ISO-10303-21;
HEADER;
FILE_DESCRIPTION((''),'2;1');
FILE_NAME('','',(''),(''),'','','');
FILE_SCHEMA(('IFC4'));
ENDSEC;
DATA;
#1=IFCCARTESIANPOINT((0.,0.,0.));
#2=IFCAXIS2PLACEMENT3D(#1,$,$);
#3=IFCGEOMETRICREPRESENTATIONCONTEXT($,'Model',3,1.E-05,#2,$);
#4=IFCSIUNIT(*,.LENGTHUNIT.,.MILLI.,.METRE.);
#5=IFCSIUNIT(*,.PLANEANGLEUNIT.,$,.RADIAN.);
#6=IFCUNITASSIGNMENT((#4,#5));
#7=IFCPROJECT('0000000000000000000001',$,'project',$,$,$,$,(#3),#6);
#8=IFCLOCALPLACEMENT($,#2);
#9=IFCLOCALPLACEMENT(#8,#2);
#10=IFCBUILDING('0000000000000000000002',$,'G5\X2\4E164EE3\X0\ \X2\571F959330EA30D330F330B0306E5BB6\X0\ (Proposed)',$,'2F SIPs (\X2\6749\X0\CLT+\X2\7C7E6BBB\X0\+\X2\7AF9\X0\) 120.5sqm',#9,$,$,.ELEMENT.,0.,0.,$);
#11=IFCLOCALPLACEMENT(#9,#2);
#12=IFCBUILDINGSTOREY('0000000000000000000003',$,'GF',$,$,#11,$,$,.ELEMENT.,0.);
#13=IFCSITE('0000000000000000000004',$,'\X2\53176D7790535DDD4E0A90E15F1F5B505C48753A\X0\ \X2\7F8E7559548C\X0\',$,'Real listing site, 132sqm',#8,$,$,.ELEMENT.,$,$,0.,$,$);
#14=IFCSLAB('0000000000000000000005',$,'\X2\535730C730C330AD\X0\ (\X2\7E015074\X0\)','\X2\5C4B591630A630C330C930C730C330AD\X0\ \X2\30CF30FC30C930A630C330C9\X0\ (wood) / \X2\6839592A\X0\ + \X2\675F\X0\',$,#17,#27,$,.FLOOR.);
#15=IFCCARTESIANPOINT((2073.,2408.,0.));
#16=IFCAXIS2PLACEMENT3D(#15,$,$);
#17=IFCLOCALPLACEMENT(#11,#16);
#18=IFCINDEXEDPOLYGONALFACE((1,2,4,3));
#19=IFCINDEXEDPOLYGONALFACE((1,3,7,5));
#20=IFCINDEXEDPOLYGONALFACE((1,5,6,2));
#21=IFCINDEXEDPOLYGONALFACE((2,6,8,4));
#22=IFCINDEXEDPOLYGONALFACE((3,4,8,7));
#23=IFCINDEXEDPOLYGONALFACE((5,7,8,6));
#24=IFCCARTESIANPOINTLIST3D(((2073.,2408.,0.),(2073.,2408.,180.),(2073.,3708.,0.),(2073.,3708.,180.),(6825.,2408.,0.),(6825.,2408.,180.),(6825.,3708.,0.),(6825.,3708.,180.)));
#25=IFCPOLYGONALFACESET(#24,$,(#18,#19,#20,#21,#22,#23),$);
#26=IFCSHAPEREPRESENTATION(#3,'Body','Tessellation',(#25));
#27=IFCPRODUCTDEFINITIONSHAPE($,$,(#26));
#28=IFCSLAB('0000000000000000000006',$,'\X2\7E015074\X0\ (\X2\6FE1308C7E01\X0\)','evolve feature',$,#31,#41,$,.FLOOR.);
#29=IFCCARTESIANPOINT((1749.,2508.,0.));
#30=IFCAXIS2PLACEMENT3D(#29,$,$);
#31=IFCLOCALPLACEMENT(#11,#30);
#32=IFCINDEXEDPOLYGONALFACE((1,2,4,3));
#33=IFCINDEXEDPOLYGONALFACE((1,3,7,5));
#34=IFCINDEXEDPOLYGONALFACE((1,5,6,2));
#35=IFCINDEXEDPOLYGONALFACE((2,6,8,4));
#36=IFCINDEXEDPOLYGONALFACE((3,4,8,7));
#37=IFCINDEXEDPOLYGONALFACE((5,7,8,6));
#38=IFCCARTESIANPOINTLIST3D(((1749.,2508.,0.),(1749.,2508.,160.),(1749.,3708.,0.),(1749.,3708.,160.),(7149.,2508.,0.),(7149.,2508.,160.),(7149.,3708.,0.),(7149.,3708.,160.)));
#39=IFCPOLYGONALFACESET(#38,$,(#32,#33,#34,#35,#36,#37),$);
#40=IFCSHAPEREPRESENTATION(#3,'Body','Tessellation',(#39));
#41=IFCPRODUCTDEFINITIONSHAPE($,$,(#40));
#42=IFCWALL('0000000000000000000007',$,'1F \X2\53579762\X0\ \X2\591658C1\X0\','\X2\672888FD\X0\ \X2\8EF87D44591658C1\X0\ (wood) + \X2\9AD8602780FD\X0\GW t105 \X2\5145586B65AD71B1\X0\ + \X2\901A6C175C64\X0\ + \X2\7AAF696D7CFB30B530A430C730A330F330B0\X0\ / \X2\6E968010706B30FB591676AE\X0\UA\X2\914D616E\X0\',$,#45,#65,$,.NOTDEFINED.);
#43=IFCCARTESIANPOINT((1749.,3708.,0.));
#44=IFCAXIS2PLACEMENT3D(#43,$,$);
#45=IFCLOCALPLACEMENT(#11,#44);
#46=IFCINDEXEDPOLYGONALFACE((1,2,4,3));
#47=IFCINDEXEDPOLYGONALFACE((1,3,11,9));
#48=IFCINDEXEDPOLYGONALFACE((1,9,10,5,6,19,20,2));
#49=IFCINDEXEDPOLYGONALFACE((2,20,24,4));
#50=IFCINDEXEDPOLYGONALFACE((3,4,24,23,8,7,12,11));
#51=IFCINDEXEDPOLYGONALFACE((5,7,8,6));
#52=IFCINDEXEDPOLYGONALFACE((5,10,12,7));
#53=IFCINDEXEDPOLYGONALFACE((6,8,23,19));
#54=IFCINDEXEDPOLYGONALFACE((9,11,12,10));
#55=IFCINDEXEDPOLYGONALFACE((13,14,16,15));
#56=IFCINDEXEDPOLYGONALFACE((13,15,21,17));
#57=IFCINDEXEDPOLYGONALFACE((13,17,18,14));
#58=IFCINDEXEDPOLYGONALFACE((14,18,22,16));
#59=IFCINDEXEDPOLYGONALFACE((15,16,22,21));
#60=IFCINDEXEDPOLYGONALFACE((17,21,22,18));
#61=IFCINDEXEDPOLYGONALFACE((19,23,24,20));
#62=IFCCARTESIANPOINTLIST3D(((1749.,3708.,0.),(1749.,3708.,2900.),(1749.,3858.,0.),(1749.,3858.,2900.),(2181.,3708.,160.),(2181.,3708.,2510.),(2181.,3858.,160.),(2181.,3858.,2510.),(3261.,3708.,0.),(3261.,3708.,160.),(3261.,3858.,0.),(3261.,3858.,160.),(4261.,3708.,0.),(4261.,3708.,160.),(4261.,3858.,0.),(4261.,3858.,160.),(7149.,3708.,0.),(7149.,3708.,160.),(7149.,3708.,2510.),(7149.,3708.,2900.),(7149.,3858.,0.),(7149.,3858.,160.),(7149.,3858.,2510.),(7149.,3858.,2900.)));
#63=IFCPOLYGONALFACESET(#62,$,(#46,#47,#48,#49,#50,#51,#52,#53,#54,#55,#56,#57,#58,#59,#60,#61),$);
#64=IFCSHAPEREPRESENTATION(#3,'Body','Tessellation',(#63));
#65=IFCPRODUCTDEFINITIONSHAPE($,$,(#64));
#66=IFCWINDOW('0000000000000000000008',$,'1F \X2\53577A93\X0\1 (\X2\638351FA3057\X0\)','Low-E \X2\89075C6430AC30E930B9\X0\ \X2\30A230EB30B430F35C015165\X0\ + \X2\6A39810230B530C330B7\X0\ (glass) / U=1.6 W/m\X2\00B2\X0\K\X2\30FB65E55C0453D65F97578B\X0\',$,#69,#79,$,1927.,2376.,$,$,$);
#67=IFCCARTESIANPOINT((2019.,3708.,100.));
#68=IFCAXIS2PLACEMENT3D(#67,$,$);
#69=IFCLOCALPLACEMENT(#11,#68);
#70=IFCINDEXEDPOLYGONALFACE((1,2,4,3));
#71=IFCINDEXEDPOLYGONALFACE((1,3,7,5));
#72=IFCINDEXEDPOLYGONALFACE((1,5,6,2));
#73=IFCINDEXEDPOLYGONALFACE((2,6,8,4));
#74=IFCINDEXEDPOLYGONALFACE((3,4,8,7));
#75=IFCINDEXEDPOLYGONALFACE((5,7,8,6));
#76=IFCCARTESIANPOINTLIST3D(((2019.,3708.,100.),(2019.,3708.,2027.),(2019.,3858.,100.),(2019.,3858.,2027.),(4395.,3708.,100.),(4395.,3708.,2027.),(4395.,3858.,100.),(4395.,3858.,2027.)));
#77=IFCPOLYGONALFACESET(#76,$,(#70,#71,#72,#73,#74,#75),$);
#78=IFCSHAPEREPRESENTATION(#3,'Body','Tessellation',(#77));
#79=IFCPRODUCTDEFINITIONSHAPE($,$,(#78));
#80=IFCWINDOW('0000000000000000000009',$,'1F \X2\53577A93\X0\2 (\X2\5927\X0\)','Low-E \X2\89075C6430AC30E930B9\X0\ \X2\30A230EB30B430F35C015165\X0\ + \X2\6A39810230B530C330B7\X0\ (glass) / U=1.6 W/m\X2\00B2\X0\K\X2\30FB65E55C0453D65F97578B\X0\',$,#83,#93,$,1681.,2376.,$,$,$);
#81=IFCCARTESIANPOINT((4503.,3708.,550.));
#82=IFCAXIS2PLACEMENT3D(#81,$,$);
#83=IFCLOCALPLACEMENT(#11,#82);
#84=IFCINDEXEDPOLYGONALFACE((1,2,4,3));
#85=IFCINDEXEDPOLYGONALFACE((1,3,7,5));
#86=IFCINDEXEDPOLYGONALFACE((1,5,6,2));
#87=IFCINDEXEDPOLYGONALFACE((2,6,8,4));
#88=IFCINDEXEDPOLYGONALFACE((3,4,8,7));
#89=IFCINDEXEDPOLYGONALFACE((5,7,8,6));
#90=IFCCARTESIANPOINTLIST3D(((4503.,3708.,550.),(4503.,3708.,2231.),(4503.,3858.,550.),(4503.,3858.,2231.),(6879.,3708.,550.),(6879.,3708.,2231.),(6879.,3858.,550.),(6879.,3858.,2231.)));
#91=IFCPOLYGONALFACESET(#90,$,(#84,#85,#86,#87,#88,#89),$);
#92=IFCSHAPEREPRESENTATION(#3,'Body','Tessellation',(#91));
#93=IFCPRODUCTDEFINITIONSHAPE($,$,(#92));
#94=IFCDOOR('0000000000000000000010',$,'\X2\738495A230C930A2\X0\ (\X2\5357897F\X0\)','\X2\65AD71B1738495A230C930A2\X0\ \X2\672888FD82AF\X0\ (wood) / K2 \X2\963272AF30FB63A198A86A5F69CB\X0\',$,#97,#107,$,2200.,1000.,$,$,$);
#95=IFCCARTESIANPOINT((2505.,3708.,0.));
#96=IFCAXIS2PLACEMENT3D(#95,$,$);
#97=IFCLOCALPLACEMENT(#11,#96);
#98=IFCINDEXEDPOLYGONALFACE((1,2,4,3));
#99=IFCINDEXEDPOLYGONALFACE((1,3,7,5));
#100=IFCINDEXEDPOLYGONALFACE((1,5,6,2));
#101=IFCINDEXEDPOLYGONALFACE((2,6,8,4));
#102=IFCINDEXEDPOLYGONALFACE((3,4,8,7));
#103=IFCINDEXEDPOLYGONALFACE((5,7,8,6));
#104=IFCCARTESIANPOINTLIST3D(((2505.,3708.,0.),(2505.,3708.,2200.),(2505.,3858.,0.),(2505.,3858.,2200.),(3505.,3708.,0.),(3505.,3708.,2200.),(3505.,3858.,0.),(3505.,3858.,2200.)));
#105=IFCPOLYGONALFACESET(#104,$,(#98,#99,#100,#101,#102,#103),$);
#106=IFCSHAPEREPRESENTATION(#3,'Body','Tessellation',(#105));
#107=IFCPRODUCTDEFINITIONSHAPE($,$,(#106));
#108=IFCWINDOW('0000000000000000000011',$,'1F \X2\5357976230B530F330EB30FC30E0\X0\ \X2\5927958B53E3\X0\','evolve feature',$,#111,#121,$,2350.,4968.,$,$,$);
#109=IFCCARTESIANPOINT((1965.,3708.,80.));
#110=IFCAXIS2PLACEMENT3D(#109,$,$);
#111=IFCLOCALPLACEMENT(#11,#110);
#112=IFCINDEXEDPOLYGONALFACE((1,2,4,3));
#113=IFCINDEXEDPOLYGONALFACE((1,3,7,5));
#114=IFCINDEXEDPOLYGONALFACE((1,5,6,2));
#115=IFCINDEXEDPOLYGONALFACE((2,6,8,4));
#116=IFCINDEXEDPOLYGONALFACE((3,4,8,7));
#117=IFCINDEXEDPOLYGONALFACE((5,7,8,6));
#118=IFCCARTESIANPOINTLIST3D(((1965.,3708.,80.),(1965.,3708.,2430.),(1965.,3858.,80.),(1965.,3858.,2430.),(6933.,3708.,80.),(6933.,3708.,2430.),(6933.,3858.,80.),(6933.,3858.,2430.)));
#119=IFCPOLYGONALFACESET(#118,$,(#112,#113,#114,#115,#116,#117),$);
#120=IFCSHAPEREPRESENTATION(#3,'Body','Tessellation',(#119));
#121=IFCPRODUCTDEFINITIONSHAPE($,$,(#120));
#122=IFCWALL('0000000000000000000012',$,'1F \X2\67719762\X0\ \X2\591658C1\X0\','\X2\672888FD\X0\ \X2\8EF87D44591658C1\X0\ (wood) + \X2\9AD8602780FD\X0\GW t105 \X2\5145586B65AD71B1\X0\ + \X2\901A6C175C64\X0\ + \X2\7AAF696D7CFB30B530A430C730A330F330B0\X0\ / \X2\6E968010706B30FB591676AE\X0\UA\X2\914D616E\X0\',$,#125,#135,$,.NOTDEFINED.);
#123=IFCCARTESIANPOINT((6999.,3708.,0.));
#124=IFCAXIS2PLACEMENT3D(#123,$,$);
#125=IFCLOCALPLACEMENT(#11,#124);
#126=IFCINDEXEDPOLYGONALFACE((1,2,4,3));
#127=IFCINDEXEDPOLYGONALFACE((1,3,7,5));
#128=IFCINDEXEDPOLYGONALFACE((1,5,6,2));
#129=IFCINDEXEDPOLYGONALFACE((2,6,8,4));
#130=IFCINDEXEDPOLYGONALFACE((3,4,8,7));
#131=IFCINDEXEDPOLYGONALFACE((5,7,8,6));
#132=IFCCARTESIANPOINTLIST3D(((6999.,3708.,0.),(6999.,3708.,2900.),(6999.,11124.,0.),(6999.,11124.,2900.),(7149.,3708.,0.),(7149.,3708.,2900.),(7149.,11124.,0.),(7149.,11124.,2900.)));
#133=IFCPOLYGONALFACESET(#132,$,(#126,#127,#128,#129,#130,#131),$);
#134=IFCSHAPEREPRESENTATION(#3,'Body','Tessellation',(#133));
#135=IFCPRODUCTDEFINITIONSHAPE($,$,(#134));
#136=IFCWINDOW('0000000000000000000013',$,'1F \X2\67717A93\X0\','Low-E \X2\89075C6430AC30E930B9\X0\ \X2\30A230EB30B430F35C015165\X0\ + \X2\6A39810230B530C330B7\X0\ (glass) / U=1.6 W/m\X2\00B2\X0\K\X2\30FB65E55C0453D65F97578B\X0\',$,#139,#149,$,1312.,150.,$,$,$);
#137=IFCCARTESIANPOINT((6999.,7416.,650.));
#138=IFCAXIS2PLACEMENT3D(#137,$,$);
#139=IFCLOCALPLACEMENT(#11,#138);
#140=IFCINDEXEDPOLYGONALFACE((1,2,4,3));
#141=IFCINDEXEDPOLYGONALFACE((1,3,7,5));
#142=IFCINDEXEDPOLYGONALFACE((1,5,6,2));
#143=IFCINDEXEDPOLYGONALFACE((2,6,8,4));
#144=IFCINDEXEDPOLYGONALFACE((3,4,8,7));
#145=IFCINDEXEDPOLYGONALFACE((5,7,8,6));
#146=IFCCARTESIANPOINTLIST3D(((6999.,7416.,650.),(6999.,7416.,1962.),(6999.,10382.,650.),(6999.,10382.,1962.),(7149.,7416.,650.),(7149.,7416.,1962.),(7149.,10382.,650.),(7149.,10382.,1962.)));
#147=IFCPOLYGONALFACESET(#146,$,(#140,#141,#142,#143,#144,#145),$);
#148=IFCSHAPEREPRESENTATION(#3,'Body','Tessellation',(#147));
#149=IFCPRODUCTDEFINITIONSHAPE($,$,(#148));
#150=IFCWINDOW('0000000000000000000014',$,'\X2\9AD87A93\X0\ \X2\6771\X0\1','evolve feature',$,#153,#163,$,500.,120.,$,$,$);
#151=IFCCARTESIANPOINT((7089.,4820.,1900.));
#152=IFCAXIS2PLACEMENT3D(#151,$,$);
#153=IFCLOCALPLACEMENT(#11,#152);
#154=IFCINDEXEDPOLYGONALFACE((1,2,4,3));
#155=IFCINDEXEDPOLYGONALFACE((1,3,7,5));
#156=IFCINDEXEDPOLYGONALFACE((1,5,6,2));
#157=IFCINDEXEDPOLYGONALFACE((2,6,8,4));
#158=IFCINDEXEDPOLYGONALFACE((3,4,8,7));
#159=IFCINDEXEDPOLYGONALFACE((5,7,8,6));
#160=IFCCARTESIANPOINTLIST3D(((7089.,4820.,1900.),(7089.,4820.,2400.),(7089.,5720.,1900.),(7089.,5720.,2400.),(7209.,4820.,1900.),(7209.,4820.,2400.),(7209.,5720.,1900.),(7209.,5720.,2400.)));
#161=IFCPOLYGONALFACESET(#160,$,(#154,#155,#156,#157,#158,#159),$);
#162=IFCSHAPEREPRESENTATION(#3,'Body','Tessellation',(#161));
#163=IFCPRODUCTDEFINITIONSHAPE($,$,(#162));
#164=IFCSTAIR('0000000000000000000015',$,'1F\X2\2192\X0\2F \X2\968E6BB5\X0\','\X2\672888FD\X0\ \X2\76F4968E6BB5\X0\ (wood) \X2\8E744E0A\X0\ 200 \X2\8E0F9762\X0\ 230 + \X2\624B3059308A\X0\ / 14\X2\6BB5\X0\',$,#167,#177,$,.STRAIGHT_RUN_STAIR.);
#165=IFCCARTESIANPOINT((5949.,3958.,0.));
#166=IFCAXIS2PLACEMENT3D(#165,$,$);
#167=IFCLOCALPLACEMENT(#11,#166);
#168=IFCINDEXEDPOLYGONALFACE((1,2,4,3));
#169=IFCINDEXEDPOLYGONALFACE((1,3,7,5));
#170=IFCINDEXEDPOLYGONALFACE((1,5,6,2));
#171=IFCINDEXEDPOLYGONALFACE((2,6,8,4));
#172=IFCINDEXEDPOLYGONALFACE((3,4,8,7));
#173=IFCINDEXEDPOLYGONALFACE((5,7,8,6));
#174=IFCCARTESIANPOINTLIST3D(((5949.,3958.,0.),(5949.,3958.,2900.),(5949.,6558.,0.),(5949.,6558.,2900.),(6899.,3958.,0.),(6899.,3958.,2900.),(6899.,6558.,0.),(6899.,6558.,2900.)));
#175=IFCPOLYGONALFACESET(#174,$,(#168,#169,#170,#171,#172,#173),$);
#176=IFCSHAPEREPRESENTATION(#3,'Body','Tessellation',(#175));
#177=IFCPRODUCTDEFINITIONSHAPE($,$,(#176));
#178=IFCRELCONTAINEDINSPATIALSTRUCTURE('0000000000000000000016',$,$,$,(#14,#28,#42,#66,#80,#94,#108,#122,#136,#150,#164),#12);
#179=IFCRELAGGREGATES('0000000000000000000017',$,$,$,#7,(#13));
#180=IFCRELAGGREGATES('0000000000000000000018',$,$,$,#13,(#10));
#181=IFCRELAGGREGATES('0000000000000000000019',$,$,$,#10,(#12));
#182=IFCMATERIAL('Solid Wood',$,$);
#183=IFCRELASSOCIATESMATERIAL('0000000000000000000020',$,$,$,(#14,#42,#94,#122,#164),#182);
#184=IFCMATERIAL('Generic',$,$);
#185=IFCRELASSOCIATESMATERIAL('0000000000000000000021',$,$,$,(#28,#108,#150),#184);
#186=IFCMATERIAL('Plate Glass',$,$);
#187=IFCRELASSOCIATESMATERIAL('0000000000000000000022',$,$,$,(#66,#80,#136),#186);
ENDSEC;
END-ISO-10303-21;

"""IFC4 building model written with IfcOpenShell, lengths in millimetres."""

from ifc_helpers import new_model, si_unit, frame, frame_2d, origin, place, context, project, spatial, rectangle, extrude, material, element, fill, save


model = new_model("IFC4")

# Units and contexts
model_context = context("Model", 3, precision=1e-05, world=origin())
ifc_project = project(units=[si_unit("LENGTHUNIT", "METRE", prefix="MILLI"), si_unit("PLANEANGLEUNIT", "RADIAN")], contexts=[model_context])

# Site, building, storey
site_placement = place(None, origin())
site = spatial("IfcSite", under=ifc_project, at=site_placement, Name="北海道川上郡弟子屈町 美留和", ObjectType="Real listing site, 132sqm", CompositionType="ELEMENT", RefElevation=0.0)
building_placement = place(site_placement, origin())
building = spatial("IfcBuilding", under=site, at=building_placement, Name="G5世代 土間リビングの家 (Proposed)", ObjectType="2F SIPs (杉CLT+籾殻+竹) 120.5sqm", CompositionType="ELEMENT", ElevationOfRefHeight=0.0, ElevationOfTerrain=0.0)
storey_placement = place(building_placement, origin())
storey = spatial("IfcBuildingStorey", under=building, at=storey_placement, Name="GF", CompositionType="ELEMENT", Elevation=0.0)

# Slabs
ifc_material_1 = material(Name="Solid Wood")
slab_1_placement = place(storey_placement, frame((2073.0, 2408.0, 0.0)))
element("IfcSlab", 1, at=slab_1_placement, inside=storey, material=ifc_material_1, Name="南デッキ (縁側)", Description="屋外ウッドデッキ ハードウッド (wood) / 根太 + 束", PredefinedType="FLOOR", context=model_context, shape_type="SweptSolid", body=[
    extrude(rectangle(XDim=4752.0, YDim=1300.0, at=frame_2d((2376.0, 650.0))), frame((2073.0, 2408.0, 0.0)), (0.0, 0.0, 1.0), 180.0),
])
ifc_material_2 = material(Name="Generic")
slab_2_placement = place(storey_placement, frame((1749.0, 2508.0, 0.0)))
element("IfcSlab", 2, at=slab_2_placement, inside=storey, material=ifc_material_2, Name="縁側 (濡れ縁)", Description="evolve feature", PredefinedType="FLOOR", context=model_context, shape_type="SweptSolid", body=[
    extrude(rectangle(XDim=5400.0, YDim=1200.0, at=frame_2d((2700.0, 600.0))), frame((1749.0, 2508.0, 0.0)), (0.0, 0.0, 1.0), 160.0),
])

# Wall, openings, windows, door
wall_1_placement = place(storey_placement, frame((1749.0, 3708.0, 0.0)))
wall_1 = element("IfcWall", 3, at=wall_1_placement, inside=storey, material=ifc_material_1, Name="1F 南面 外壁", Description="木製 軸組外壁 (wood) + 高性能GW t105 充填断熱 + 通気層 + 窯業系サイディング / 準耐火・外皮UA配慮", PredefinedType="NOTDEFINED", context=model_context, shape_type="SweptSolid", body=[
    extrude(rectangle(XDim=5400.0, YDim=150.0, at=frame_2d((2700.0, 75.0))), frame((1749.0, 3708.0, 0.0)), (0.0, 0.0, 1.0), 2900.0),
])
opening_1_placement = place(storey_placement, frame((2019.0, 3708.0, 100.0)))
opening_1 = element("IfcOpeningElement", 4, at=opening_1_placement, cuts=wall_1, PredefinedType="NOTDEFINED", context=model_context, shape_type="SweptSolid", body=[
    extrude(rectangle(XDim=2376.0, YDim=150.0, at=frame_2d((1188.0, 75.0))), frame((2019.0, 3708.0, 100.0)), (0.0, 0.0, 1.0), 1927.0),
])
opening_2_placement = place(storey_placement, frame((4503.0, 3708.0, 550.0)))
opening_2 = element("IfcOpeningElement", 5, at=opening_2_placement, cuts=wall_1, PredefinedType="NOTDEFINED", context=model_context, shape_type="SweptSolid", body=[
    extrude(rectangle(XDim=2376.0, YDim=150.0, at=frame_2d((1188.0, 75.0))), frame((4503.0, 3708.0, 550.0)), (0.0, 0.0, 1.0), 1681.0),
])
opening_3_placement = place(storey_placement, frame((2505.0, 3708.0, 0.0)))
opening_3 = element("IfcOpeningElement", 6, at=opening_3_placement, cuts=wall_1, PredefinedType="NOTDEFINED", context=model_context, shape_type="SweptSolid", body=[
    extrude(rectangle(XDim=1000.0, YDim=150.0, at=frame_2d((500.0, 75.0))), frame((2505.0, 3708.0, 0.0)), (0.0, 0.0, 1.0), 2200.0),
])
opening_4_placement = place(storey_placement, frame((1965.0, 3708.0, 80.0)))
opening_4 = element("IfcOpeningElement", 7, at=opening_4_placement, cuts=wall_1, PredefinedType="NOTDEFINED", context=model_context, shape_type="SweptSolid", body=[
    extrude(rectangle(XDim=4968.0, YDim=150.0, at=frame_2d((2484.0, 75.0))), frame((1965.0, 3708.0, 80.0)), (0.0, 0.0, 1.0), 2350.0),
])
ifc_material_3 = material(Name="Plate Glass")
window_1_placement = place(storey_placement, frame((2019.0, 3708.0, 100.0)))
window_1 = element("IfcWindow", 8, at=window_1_placement, inside=storey, material=ifc_material_3, Name="1F 南窓1 (掃出し)", Description="Low-E 複層ガラス アルゴン封入 + 樹脂サッシ (glass) / U=1.6 W/m²K・日射取得型", OverallHeight=1927.0, OverallWidth=2376.0, context=model_context, shape_type="SweptSolid", body=[
    extrude(rectangle(XDim=2376.0, YDim=150.0, at=frame_2d((1188.0, 75.0))), frame((2019.0, 3708.0, 100.0)), (0.0, 0.0, 1.0), 1927.0),
])
fill(opening_1, window_1)
window_2_placement = place(storey_placement, frame((4503.0, 3708.0, 550.0)))
window_2 = element("IfcWindow", 9, at=window_2_placement, inside=storey, material=ifc_material_3, Name="1F 南窓2 (大)", Description="Low-E 複層ガラス アルゴン封入 + 樹脂サッシ (glass) / U=1.6 W/m²K・日射取得型", OverallHeight=1681.0, OverallWidth=2376.0, context=model_context, shape_type="SweptSolid", body=[
    extrude(rectangle(XDim=2376.0, YDim=150.0, at=frame_2d((1188.0, 75.0))), frame((4503.0, 3708.0, 550.0)), (0.0, 0.0, 1.0), 1681.0),
])
fill(opening_2, window_2)
door_placement = place(storey_placement, frame((2505.0, 3708.0, 0.0)))
door = element("IfcDoor", 10, at=door_placement, inside=storey, material=ifc_material_1, Name="玄関ドア (南西)", Description="断熱玄関ドア 木製芯 (wood) / K2 防犯・採風機構", OverallHeight=2200.0, OverallWidth=1000.0, context=model_context, shape_type="SweptSolid", body=[
    extrude(rectangle(XDim=1000.0, YDim=150.0, at=frame_2d((500.0, 75.0))), frame((2505.0, 3708.0, 0.0)), (0.0, 0.0, 1.0), 2200.0),
])
fill(opening_3, door)
window_3_placement = place(storey_placement, frame((1965.0, 3708.0, 80.0)))
window_3 = element("IfcWindow", 11, at=window_3_placement, inside=storey, material=ifc_material_2, Name="1F 南面サンルーム 大開口", Description="evolve feature", OverallHeight=2350.0, OverallWidth=4968.0, context=model_context, shape_type="SweptSolid", body=[
    extrude(rectangle(XDim=4968.0, YDim=150.0, at=frame_2d((2484.0, 75.0))), frame((1965.0, 3708.0, 80.0)), (0.0, 0.0, 1.0), 2350.0),
])
fill(opening_4, window_3)

# Wall, openings, windows
wall_2_placement = place(storey_placement, frame((6999.0, 3708.0, 0.0)))
wall_2 = element("IfcWall", 12, at=wall_2_placement, inside=storey, material=ifc_material_1, Name="1F 東面 外壁", Description="木製 軸組外壁 (wood) + 高性能GW t105 充填断熱 + 通気層 + 窯業系サイディング / 準耐火・外皮UA配慮", PredefinedType="NOTDEFINED", context=model_context, shape_type="SweptSolid", body=[
    extrude(rectangle(XDim=150.0, YDim=7416.0, at=frame_2d((75.0, 3708.0))), frame((6999.0, 3708.0, 0.0)), (0.0, 0.0, 1.0), 2900.0),
])
opening_5_placement = place(storey_placement, frame((6999.0, 7416.0, 650.0)))
opening_5 = element("IfcOpeningElement", 13, at=opening_5_placement, cuts=wall_2, PredefinedType="NOTDEFINED", context=model_context, shape_type="SweptSolid", body=[
    extrude(rectangle(XDim=150.0, YDim=2966.0, at=frame_2d((75.0, 1483.0))), frame((6999.0, 7416.0, 650.0)), (0.0, 0.0, 1.0), 1312.0),
])
opening_6_placement = place(storey_placement, frame((7089.0, 4820.0, 1900.0)))
opening_6 = element("IfcOpeningElement", 14, at=opening_6_placement, cuts=wall_2, PredefinedType="NOTDEFINED", context=model_context, shape_type="SweptSolid", body=[
    extrude(rectangle(XDim=120.0, YDim=900.0, at=frame_2d((60.0, 450.0))), frame((7089.0, 4820.0, 1900.0)), (0.0, 0.0, 1.0), 500.0),
])
window_4_placement = place(storey_placement, frame((6999.0, 7416.0, 650.0)))
window_4 = element("IfcWindow", 15, at=window_4_placement, inside=storey, material=ifc_material_3, Name="1F 東窓", Description="Low-E 複層ガラス アルゴン封入 + 樹脂サッシ (glass) / U=1.6 W/m²K・日射取得型", OverallHeight=1312.0, OverallWidth=150.0, context=model_context, shape_type="SweptSolid", body=[
    extrude(rectangle(XDim=150.0, YDim=2966.0, at=frame_2d((75.0, 1483.0))), frame((6999.0, 7416.0, 650.0)), (0.0, 0.0, 1.0), 1312.0),
])
fill(opening_5, window_4)
window_5_placement = place(storey_placement, frame((7089.0, 4820.0, 1900.0)))
window_5 = element("IfcWindow", 16, at=window_5_placement, inside=storey, material=ifc_material_2, Name="高窓 東1", Description="evolve feature", OverallHeight=500.0, OverallWidth=120.0, context=model_context, shape_type="SweptSolid", body=[
    extrude(rectangle(XDim=120.0, YDim=900.0, at=frame_2d((60.0, 450.0))), frame((7089.0, 4820.0, 1900.0)), (0.0, 0.0, 1.0), 500.0),
])
fill(opening_6, window_5)

# Stair
stair_placement = place(storey_placement, frame((5949.0, 3958.0, 0.0)))
element("IfcStair", 17, at=stair_placement, inside=storey, material=ifc_material_1, Name="1F→2F 階段", Description="木製 直階段 (wood) 蹴上 200 踏面 230 + 手すり / 14段", PredefinedType="STRAIGHT_RUN_STAIR", context=model_context, shape_type="SweptSolid", body=[
    extrude(rectangle(XDim=950.0, YDim=2600.0, at=frame_2d((475.0, 1300.0))), frame((5949.0, 3958.0, 0.0)), (0.0, 0.0, 1.0), 2900.0),
])

save(model, "model.ifc")
